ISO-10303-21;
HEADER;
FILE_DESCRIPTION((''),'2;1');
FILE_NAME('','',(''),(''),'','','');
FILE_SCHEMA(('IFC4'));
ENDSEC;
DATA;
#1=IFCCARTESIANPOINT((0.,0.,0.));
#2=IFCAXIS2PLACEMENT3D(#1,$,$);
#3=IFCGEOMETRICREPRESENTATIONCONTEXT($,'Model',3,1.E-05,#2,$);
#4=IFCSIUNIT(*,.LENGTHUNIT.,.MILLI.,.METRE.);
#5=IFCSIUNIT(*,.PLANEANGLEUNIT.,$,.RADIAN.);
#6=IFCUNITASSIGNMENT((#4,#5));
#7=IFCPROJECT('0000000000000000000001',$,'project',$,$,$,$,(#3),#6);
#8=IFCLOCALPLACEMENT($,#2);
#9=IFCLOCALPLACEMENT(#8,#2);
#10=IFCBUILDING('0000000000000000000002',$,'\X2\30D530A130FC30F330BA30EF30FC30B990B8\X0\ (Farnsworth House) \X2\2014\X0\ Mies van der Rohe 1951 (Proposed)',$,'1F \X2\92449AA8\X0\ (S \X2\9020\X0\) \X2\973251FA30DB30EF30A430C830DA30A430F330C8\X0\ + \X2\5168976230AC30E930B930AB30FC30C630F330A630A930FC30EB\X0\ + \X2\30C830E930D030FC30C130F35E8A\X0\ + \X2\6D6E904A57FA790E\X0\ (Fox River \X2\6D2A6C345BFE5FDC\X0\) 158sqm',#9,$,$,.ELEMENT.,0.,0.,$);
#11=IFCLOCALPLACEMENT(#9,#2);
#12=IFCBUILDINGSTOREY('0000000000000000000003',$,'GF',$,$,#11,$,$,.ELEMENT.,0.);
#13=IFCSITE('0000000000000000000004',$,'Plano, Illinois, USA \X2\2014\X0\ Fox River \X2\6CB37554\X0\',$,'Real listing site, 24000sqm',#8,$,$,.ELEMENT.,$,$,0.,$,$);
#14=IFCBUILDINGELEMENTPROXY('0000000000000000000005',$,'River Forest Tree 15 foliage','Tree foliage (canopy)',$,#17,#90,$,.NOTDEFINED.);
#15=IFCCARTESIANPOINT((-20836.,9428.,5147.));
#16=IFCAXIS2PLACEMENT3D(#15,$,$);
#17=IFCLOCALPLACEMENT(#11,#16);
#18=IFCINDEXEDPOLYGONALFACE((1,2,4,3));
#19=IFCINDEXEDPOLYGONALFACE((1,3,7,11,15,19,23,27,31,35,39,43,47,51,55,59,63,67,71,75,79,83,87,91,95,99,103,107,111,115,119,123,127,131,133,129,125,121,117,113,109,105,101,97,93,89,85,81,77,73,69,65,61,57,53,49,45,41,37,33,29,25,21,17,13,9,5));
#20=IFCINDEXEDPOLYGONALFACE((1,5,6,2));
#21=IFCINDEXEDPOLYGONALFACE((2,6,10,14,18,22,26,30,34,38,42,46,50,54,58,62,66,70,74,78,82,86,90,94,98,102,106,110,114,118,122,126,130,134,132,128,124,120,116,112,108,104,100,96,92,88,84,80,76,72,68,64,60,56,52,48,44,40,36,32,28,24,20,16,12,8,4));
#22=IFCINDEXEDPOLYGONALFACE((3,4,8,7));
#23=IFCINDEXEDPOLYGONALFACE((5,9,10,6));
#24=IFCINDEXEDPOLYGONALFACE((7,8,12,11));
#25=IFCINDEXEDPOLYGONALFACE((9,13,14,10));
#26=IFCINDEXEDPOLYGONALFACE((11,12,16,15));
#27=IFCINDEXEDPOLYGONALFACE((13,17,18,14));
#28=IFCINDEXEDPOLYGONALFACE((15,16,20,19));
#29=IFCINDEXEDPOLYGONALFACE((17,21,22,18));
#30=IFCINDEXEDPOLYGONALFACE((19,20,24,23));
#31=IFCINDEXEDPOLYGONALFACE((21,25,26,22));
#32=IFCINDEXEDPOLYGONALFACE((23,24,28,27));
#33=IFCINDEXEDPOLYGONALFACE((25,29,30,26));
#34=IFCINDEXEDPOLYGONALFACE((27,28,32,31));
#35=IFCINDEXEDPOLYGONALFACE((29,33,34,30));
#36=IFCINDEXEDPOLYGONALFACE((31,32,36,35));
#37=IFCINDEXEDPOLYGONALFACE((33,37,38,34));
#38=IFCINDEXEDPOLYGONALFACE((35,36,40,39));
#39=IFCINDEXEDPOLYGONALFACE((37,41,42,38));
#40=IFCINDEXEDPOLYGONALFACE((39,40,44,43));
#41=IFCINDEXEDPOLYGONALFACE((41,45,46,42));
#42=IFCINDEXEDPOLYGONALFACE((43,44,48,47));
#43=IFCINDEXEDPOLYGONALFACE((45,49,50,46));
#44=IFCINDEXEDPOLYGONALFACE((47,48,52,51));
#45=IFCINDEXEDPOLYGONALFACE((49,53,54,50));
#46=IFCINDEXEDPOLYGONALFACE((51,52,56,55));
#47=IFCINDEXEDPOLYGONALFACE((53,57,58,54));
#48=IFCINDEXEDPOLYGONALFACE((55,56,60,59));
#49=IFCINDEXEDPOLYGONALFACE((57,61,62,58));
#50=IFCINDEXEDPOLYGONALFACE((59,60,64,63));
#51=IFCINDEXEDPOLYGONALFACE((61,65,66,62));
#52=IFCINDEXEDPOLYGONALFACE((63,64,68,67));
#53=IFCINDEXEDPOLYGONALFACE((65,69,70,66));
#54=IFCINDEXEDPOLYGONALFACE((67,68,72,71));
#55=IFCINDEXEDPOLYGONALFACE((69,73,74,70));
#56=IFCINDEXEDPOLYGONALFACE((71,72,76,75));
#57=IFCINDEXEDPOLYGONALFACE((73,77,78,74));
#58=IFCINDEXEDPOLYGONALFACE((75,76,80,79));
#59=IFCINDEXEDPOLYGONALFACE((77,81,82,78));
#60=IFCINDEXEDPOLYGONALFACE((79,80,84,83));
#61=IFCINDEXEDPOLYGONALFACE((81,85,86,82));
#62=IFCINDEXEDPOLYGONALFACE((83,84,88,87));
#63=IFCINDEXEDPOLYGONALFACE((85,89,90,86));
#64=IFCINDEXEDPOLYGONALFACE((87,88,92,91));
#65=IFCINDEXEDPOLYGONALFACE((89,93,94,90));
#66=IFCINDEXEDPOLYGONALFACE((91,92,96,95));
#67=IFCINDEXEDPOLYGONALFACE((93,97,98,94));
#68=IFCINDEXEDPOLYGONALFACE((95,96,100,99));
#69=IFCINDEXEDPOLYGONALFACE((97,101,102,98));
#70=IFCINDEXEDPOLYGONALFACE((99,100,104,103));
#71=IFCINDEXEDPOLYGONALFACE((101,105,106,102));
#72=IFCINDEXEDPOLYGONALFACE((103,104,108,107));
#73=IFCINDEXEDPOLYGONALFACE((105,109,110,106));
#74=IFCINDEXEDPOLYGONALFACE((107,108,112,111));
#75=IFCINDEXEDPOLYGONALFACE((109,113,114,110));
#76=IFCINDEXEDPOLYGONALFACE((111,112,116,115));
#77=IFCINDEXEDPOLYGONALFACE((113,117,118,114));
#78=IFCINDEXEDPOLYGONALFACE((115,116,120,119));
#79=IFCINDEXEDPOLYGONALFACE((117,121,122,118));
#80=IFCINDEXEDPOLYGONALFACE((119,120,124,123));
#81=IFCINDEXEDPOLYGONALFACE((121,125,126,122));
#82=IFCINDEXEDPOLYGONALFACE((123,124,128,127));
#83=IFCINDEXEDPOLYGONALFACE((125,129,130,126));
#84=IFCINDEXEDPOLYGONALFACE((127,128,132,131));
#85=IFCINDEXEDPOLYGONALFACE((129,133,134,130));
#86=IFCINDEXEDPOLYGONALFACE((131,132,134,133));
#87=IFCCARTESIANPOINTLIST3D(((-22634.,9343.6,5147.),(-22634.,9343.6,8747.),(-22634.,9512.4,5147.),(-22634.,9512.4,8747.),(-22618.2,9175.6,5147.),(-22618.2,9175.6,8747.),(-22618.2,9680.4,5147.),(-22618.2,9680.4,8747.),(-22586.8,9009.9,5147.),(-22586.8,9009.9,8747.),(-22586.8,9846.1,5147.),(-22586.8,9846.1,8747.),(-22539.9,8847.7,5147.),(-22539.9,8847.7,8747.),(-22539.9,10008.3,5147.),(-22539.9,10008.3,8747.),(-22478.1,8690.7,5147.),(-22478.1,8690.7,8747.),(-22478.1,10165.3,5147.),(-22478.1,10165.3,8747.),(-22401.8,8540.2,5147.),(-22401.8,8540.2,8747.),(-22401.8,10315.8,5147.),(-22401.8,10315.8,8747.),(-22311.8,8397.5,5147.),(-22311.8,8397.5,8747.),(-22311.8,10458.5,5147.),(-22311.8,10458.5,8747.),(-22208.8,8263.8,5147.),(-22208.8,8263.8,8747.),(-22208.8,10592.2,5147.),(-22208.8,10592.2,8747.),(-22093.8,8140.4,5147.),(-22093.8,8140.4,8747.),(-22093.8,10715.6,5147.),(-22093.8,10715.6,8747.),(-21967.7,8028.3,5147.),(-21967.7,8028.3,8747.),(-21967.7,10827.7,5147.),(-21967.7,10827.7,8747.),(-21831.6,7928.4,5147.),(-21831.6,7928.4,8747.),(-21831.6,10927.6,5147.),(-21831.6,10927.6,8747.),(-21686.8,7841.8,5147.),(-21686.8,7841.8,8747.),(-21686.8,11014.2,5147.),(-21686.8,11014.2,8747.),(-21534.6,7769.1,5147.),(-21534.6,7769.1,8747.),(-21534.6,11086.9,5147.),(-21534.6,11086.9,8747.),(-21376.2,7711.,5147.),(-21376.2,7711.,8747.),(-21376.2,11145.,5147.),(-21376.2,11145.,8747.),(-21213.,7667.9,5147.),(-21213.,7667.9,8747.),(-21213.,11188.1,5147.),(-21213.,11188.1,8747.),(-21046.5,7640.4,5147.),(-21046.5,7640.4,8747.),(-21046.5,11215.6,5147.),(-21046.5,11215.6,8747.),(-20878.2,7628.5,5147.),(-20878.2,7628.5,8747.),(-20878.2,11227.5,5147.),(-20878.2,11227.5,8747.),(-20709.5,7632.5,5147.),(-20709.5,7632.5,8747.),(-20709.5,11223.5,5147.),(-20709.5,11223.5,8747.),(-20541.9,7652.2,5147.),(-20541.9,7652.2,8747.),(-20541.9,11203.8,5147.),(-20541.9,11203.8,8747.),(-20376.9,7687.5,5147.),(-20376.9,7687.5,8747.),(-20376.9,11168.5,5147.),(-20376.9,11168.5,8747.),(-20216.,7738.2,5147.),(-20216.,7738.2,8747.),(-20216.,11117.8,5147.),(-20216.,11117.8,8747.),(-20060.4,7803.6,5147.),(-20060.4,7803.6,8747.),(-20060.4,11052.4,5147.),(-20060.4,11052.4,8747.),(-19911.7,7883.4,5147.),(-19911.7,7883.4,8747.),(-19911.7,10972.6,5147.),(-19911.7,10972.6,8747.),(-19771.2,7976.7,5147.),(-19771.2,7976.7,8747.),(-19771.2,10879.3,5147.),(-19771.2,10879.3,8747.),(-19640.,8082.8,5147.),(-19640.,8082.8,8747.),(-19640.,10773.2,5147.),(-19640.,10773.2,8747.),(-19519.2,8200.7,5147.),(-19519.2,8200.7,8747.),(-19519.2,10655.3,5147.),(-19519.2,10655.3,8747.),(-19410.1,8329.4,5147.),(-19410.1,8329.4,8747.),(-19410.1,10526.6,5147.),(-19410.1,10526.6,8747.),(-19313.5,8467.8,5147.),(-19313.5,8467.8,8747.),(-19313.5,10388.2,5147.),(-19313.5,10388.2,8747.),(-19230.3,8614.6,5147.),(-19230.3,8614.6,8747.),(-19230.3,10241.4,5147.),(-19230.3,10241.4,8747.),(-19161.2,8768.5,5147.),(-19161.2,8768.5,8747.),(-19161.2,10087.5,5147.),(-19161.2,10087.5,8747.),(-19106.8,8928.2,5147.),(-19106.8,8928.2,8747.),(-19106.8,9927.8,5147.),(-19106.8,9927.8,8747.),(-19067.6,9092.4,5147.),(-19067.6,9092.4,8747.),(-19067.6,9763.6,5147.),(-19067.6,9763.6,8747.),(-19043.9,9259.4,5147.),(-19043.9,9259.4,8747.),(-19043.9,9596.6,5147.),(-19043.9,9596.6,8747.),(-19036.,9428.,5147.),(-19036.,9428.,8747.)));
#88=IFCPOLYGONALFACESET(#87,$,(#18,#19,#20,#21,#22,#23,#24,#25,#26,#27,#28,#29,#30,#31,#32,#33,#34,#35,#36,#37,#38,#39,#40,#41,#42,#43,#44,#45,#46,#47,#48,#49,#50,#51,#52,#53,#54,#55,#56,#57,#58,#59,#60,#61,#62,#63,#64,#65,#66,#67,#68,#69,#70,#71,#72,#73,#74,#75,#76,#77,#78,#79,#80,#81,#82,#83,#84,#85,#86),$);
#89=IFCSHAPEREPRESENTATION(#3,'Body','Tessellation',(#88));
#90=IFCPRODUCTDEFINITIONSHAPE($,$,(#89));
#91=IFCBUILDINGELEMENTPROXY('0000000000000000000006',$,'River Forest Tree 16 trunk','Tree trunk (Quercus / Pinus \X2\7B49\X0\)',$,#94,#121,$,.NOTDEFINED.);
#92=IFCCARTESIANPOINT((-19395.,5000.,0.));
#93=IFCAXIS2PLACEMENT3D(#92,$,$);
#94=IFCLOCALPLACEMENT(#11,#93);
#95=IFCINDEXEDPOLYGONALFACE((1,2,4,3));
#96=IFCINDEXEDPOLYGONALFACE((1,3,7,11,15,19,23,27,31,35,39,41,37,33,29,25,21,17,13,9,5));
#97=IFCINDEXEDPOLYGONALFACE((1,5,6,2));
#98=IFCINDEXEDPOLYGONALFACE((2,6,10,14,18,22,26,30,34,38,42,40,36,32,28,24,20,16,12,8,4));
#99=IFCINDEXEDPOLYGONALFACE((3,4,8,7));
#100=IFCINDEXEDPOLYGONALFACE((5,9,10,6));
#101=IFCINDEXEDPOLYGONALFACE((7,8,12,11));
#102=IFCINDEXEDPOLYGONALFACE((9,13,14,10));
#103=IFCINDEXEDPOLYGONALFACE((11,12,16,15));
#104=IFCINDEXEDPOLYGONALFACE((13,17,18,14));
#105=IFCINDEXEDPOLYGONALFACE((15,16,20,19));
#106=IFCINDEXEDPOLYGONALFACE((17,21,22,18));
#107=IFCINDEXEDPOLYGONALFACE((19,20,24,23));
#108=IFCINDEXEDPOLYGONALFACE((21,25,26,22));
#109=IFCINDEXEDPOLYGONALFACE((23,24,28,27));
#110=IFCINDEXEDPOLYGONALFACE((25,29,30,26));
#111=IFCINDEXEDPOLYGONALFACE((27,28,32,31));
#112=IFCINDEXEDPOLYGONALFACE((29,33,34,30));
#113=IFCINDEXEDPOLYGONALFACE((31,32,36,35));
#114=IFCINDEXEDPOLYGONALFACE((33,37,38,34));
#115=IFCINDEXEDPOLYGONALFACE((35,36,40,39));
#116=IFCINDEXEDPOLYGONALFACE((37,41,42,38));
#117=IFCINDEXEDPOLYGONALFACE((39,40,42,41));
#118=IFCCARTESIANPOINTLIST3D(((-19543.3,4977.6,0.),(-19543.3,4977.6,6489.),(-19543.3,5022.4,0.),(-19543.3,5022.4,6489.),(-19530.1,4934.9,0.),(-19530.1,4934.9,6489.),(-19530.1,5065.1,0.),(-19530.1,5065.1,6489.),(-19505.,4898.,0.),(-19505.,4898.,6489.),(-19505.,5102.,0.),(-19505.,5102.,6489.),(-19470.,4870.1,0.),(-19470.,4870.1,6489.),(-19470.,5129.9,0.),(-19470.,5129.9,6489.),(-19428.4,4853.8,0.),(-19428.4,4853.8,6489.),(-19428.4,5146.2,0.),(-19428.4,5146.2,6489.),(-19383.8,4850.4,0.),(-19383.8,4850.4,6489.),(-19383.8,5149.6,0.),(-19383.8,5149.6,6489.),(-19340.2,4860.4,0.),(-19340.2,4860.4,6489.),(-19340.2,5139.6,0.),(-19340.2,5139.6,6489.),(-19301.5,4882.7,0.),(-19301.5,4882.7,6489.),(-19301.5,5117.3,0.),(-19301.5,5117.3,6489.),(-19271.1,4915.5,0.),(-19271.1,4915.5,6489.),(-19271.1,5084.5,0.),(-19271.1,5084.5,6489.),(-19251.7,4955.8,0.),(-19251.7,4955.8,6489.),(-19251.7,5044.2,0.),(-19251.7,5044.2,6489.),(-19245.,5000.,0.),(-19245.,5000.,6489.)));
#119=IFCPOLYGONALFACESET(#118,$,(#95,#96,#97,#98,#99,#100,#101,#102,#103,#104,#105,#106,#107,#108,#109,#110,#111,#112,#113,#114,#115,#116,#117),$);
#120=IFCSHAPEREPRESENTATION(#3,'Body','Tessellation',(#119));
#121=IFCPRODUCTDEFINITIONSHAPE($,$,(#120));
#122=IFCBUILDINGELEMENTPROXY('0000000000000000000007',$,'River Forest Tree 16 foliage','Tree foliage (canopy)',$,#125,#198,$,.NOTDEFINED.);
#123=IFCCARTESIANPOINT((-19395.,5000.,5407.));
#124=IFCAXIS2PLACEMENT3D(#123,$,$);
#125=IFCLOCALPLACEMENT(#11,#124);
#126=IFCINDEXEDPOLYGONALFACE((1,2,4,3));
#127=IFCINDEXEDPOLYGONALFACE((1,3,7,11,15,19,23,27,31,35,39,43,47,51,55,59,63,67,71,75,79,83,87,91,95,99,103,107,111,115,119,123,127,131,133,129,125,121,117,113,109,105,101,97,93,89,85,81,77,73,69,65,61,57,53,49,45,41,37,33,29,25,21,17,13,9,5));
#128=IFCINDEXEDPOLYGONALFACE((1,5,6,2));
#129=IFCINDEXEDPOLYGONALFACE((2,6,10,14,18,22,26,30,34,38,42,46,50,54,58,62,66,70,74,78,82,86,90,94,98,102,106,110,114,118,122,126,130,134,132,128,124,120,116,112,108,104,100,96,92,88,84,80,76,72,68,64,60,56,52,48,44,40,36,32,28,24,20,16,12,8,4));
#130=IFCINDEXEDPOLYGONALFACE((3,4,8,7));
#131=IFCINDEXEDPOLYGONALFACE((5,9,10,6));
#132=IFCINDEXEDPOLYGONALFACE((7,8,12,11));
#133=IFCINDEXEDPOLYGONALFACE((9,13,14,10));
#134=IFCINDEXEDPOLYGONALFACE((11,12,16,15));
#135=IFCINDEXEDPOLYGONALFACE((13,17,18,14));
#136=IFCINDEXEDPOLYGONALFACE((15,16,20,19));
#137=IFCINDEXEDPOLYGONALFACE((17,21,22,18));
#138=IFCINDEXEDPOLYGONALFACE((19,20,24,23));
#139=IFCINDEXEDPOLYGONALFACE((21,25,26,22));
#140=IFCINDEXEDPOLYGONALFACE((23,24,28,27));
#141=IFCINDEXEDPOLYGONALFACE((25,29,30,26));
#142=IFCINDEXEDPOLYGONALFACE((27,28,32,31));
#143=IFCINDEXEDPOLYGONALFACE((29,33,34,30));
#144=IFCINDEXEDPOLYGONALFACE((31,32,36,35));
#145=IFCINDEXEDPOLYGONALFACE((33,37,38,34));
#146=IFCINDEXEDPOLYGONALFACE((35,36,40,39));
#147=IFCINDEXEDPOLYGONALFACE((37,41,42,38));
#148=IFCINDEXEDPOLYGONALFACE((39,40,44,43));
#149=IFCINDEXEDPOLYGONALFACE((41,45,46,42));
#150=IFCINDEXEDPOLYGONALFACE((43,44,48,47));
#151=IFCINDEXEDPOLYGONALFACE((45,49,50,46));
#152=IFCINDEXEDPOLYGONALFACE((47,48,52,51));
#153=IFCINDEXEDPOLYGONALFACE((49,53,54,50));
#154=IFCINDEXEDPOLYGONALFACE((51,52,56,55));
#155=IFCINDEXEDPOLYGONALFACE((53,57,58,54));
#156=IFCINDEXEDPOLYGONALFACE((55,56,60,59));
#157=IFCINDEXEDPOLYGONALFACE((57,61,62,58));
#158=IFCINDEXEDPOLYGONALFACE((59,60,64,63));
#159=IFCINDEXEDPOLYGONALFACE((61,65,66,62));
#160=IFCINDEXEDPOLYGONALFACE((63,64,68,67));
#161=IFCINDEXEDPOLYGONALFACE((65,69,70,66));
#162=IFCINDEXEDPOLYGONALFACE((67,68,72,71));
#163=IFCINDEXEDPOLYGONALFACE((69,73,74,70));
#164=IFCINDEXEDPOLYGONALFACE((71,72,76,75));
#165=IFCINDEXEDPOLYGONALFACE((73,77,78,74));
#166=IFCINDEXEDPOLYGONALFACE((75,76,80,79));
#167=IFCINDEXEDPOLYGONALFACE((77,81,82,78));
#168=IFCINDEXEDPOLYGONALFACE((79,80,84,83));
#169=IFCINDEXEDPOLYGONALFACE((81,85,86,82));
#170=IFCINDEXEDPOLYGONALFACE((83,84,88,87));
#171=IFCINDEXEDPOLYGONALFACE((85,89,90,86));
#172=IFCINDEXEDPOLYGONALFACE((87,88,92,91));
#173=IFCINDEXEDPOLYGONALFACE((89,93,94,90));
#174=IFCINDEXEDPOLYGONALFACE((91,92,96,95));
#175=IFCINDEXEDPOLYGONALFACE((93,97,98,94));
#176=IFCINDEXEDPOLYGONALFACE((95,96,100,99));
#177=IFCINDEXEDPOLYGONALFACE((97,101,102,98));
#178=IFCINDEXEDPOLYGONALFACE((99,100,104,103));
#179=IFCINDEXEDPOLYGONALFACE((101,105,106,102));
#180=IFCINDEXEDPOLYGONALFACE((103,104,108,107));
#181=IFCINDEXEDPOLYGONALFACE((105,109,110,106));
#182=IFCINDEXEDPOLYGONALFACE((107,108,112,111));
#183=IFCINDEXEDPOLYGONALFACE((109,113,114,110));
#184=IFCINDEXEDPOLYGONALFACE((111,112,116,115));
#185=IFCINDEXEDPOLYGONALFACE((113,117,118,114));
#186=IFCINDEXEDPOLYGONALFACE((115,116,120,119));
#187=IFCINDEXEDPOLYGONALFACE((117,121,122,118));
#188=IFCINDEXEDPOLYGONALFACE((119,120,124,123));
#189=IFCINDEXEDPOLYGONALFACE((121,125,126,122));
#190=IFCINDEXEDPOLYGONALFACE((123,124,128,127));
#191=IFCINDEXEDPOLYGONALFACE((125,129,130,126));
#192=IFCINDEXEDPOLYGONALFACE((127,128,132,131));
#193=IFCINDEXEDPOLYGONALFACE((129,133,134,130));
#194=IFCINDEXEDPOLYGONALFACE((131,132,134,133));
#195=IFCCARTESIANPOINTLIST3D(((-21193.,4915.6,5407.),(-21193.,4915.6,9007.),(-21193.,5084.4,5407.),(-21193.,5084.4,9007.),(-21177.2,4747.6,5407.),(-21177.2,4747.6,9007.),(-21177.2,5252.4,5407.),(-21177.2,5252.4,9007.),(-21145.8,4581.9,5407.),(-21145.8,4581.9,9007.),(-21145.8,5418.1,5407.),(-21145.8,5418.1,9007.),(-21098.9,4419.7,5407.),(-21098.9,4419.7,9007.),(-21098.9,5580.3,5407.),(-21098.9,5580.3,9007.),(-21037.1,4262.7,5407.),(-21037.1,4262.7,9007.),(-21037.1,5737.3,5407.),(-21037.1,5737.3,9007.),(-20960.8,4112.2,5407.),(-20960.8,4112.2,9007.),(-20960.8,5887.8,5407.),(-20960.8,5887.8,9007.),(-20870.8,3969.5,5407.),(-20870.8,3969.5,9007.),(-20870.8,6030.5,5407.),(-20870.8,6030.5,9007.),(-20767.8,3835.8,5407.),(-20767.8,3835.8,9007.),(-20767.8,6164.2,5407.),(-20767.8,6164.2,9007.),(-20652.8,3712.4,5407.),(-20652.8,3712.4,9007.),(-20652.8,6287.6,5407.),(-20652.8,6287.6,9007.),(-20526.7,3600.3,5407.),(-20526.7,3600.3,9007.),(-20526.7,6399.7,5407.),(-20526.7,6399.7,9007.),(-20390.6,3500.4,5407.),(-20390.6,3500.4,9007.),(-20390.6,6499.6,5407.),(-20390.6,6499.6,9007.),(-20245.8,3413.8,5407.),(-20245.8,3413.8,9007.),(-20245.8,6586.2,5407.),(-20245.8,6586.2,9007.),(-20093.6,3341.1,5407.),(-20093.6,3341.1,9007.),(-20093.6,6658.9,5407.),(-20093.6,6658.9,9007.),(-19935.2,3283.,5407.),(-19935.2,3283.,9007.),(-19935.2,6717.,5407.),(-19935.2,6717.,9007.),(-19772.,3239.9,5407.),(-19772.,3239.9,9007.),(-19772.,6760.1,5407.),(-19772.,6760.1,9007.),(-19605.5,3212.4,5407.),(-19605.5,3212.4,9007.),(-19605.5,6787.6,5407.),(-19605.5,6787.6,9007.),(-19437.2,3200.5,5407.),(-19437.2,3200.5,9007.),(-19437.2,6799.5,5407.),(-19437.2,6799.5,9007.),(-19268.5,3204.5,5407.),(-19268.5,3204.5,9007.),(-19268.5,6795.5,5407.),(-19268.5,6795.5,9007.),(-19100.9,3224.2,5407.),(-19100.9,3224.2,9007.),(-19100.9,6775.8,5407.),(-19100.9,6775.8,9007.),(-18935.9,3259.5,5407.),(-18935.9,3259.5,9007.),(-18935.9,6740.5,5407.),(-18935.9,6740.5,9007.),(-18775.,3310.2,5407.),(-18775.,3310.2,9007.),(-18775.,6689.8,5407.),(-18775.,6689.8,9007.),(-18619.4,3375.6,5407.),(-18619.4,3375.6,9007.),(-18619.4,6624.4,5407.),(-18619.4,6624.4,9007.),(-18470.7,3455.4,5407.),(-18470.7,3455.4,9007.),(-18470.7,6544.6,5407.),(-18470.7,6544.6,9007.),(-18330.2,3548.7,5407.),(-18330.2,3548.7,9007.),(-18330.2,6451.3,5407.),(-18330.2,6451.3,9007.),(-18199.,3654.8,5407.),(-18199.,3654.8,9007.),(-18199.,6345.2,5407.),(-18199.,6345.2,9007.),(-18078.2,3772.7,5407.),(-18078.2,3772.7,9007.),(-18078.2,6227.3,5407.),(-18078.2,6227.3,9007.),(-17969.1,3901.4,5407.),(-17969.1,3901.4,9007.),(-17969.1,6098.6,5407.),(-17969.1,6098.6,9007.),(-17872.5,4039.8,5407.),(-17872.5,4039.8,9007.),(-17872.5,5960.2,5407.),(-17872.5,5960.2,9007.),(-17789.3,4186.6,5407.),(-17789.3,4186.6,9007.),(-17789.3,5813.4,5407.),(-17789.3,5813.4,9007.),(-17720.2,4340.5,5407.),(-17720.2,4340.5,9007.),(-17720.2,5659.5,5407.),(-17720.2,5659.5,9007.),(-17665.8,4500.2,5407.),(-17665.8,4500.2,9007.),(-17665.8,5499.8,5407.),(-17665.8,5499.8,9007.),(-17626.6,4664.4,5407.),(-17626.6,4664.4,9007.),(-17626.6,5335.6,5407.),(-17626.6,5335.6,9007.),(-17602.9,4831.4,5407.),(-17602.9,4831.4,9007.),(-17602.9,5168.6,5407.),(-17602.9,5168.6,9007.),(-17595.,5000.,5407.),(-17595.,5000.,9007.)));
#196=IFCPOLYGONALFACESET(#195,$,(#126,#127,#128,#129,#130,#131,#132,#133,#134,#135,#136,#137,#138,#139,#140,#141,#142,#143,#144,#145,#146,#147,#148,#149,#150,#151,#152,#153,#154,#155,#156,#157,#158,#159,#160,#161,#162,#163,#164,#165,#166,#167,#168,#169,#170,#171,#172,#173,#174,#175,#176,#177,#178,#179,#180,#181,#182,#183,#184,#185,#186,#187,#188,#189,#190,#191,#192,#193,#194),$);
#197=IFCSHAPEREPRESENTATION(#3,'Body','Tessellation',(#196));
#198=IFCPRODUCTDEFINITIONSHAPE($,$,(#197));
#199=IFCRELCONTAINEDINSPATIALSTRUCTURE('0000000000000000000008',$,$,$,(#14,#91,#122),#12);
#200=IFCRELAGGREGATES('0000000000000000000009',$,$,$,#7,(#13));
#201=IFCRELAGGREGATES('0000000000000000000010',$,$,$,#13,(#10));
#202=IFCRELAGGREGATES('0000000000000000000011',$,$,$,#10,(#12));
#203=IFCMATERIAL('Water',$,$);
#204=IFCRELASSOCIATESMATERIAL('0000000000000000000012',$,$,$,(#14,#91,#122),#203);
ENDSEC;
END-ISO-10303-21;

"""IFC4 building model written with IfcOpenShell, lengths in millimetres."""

from ifc_helpers import new_model, si_unit, frame, origin, origin_2d, place, context, project, spatial, circle, extrude, material, element, save


model = new_model("IFC4")

# Units and contexts
model_context = context("Model", 3, precision=1e-05, world=origin())
ifc_project = project(units=[si_unit("LENGTHUNIT", "METRE", prefix="MILLI"), si_unit("PLANEANGLEUNIT", "RADIAN")], contexts=[model_context])

# Site, building, storey
site_placement = place(None, origin())
site = spatial("IfcSite", under=ifc_project, at=site_placement, Name="Plano, Illinois, USA — Fox River 河畔", ObjectType="Real listing site, 24000sqm", CompositionType="ELEMENT", RefElevation=0.0)
building_placement = place(site_placement, origin())
building = spatial("IfcBuilding", under=site, at=building_placement, Name="ファーンズワース邸 (Farnsworth House) — Mies van der Rohe 1951 (Proposed)", ObjectType="1F 鉄骨 (S 造) 露出ホワイトペイント + 全面ガラスカーテンウォール + トラバーチン床 + 浮遊基礎 (Fox River 洪水対応) 158sqm", CompositionType="ELEMENT", ElevationOfRefHeight=0.0, ElevationOfTerrain=0.0)
storey_placement = place(building_placement, origin())
storey = spatial("IfcBuildingStorey", under=building, at=storey_placement, Name="GF", CompositionType="ELEMENT", Elevation=0.0)

# Building element proxies
ifc_material_1 = material(Name="Water")
proxy_1_placement = place(storey_placement, frame((-20836.0, 9428.0, 5147.0)))
element("IfcBuildingElementProxy", 1, at=proxy_1_placement, inside=storey, material=ifc_material_1, Name="River Forest Tree 15 foliage", Description="Tree foliage (canopy)", PredefinedType="NOTDEFINED", context=model_context, shape_type="SweptSolid", body=[
    extrude(circle(Radius=1800.0, at=origin_2d()), frame((-20836.0, 9428.0, 5147.0)), (0.0, 0.0, 1.0), 3600.0),
])
proxy_2_placement = place(storey_placement, frame((-19395.0, 5000.0, 0.0)))
element("IfcBuildingElementProxy", 2, at=proxy_2_placement, inside=storey, material=ifc_material_1, Name="River Forest Tree 16 trunk", Description="Tree trunk (Quercus / Pinus 等)", PredefinedType="NOTDEFINED", context=model_context, shape_type="SweptSolid", body=[
    extrude(circle(Radius=150.0, at=origin_2d()), frame((-19395.0, 5000.0, 0.0)), (0.0, 0.0, 1.0), 6489.0),
])
proxy_3_placement = place(storey_placement, frame((-19395.0, 5000.0, 5407.0)))
element("IfcBuildingElementProxy", 3, at=proxy_3_placement, inside=storey, material=ifc_material_1, Name="River Forest Tree 16 foliage", Description="Tree foliage (canopy)", PredefinedType="NOTDEFINED", context=model_context, shape_type="SweptSolid", body=[
    extrude(circle(Radius=1800.0, at=origin_2d()), frame((-19395.0, 5000.0, 5407.0)), (0.0, 0.0, 1.0), 3600.0),
])

save(model, "model.ifc")
